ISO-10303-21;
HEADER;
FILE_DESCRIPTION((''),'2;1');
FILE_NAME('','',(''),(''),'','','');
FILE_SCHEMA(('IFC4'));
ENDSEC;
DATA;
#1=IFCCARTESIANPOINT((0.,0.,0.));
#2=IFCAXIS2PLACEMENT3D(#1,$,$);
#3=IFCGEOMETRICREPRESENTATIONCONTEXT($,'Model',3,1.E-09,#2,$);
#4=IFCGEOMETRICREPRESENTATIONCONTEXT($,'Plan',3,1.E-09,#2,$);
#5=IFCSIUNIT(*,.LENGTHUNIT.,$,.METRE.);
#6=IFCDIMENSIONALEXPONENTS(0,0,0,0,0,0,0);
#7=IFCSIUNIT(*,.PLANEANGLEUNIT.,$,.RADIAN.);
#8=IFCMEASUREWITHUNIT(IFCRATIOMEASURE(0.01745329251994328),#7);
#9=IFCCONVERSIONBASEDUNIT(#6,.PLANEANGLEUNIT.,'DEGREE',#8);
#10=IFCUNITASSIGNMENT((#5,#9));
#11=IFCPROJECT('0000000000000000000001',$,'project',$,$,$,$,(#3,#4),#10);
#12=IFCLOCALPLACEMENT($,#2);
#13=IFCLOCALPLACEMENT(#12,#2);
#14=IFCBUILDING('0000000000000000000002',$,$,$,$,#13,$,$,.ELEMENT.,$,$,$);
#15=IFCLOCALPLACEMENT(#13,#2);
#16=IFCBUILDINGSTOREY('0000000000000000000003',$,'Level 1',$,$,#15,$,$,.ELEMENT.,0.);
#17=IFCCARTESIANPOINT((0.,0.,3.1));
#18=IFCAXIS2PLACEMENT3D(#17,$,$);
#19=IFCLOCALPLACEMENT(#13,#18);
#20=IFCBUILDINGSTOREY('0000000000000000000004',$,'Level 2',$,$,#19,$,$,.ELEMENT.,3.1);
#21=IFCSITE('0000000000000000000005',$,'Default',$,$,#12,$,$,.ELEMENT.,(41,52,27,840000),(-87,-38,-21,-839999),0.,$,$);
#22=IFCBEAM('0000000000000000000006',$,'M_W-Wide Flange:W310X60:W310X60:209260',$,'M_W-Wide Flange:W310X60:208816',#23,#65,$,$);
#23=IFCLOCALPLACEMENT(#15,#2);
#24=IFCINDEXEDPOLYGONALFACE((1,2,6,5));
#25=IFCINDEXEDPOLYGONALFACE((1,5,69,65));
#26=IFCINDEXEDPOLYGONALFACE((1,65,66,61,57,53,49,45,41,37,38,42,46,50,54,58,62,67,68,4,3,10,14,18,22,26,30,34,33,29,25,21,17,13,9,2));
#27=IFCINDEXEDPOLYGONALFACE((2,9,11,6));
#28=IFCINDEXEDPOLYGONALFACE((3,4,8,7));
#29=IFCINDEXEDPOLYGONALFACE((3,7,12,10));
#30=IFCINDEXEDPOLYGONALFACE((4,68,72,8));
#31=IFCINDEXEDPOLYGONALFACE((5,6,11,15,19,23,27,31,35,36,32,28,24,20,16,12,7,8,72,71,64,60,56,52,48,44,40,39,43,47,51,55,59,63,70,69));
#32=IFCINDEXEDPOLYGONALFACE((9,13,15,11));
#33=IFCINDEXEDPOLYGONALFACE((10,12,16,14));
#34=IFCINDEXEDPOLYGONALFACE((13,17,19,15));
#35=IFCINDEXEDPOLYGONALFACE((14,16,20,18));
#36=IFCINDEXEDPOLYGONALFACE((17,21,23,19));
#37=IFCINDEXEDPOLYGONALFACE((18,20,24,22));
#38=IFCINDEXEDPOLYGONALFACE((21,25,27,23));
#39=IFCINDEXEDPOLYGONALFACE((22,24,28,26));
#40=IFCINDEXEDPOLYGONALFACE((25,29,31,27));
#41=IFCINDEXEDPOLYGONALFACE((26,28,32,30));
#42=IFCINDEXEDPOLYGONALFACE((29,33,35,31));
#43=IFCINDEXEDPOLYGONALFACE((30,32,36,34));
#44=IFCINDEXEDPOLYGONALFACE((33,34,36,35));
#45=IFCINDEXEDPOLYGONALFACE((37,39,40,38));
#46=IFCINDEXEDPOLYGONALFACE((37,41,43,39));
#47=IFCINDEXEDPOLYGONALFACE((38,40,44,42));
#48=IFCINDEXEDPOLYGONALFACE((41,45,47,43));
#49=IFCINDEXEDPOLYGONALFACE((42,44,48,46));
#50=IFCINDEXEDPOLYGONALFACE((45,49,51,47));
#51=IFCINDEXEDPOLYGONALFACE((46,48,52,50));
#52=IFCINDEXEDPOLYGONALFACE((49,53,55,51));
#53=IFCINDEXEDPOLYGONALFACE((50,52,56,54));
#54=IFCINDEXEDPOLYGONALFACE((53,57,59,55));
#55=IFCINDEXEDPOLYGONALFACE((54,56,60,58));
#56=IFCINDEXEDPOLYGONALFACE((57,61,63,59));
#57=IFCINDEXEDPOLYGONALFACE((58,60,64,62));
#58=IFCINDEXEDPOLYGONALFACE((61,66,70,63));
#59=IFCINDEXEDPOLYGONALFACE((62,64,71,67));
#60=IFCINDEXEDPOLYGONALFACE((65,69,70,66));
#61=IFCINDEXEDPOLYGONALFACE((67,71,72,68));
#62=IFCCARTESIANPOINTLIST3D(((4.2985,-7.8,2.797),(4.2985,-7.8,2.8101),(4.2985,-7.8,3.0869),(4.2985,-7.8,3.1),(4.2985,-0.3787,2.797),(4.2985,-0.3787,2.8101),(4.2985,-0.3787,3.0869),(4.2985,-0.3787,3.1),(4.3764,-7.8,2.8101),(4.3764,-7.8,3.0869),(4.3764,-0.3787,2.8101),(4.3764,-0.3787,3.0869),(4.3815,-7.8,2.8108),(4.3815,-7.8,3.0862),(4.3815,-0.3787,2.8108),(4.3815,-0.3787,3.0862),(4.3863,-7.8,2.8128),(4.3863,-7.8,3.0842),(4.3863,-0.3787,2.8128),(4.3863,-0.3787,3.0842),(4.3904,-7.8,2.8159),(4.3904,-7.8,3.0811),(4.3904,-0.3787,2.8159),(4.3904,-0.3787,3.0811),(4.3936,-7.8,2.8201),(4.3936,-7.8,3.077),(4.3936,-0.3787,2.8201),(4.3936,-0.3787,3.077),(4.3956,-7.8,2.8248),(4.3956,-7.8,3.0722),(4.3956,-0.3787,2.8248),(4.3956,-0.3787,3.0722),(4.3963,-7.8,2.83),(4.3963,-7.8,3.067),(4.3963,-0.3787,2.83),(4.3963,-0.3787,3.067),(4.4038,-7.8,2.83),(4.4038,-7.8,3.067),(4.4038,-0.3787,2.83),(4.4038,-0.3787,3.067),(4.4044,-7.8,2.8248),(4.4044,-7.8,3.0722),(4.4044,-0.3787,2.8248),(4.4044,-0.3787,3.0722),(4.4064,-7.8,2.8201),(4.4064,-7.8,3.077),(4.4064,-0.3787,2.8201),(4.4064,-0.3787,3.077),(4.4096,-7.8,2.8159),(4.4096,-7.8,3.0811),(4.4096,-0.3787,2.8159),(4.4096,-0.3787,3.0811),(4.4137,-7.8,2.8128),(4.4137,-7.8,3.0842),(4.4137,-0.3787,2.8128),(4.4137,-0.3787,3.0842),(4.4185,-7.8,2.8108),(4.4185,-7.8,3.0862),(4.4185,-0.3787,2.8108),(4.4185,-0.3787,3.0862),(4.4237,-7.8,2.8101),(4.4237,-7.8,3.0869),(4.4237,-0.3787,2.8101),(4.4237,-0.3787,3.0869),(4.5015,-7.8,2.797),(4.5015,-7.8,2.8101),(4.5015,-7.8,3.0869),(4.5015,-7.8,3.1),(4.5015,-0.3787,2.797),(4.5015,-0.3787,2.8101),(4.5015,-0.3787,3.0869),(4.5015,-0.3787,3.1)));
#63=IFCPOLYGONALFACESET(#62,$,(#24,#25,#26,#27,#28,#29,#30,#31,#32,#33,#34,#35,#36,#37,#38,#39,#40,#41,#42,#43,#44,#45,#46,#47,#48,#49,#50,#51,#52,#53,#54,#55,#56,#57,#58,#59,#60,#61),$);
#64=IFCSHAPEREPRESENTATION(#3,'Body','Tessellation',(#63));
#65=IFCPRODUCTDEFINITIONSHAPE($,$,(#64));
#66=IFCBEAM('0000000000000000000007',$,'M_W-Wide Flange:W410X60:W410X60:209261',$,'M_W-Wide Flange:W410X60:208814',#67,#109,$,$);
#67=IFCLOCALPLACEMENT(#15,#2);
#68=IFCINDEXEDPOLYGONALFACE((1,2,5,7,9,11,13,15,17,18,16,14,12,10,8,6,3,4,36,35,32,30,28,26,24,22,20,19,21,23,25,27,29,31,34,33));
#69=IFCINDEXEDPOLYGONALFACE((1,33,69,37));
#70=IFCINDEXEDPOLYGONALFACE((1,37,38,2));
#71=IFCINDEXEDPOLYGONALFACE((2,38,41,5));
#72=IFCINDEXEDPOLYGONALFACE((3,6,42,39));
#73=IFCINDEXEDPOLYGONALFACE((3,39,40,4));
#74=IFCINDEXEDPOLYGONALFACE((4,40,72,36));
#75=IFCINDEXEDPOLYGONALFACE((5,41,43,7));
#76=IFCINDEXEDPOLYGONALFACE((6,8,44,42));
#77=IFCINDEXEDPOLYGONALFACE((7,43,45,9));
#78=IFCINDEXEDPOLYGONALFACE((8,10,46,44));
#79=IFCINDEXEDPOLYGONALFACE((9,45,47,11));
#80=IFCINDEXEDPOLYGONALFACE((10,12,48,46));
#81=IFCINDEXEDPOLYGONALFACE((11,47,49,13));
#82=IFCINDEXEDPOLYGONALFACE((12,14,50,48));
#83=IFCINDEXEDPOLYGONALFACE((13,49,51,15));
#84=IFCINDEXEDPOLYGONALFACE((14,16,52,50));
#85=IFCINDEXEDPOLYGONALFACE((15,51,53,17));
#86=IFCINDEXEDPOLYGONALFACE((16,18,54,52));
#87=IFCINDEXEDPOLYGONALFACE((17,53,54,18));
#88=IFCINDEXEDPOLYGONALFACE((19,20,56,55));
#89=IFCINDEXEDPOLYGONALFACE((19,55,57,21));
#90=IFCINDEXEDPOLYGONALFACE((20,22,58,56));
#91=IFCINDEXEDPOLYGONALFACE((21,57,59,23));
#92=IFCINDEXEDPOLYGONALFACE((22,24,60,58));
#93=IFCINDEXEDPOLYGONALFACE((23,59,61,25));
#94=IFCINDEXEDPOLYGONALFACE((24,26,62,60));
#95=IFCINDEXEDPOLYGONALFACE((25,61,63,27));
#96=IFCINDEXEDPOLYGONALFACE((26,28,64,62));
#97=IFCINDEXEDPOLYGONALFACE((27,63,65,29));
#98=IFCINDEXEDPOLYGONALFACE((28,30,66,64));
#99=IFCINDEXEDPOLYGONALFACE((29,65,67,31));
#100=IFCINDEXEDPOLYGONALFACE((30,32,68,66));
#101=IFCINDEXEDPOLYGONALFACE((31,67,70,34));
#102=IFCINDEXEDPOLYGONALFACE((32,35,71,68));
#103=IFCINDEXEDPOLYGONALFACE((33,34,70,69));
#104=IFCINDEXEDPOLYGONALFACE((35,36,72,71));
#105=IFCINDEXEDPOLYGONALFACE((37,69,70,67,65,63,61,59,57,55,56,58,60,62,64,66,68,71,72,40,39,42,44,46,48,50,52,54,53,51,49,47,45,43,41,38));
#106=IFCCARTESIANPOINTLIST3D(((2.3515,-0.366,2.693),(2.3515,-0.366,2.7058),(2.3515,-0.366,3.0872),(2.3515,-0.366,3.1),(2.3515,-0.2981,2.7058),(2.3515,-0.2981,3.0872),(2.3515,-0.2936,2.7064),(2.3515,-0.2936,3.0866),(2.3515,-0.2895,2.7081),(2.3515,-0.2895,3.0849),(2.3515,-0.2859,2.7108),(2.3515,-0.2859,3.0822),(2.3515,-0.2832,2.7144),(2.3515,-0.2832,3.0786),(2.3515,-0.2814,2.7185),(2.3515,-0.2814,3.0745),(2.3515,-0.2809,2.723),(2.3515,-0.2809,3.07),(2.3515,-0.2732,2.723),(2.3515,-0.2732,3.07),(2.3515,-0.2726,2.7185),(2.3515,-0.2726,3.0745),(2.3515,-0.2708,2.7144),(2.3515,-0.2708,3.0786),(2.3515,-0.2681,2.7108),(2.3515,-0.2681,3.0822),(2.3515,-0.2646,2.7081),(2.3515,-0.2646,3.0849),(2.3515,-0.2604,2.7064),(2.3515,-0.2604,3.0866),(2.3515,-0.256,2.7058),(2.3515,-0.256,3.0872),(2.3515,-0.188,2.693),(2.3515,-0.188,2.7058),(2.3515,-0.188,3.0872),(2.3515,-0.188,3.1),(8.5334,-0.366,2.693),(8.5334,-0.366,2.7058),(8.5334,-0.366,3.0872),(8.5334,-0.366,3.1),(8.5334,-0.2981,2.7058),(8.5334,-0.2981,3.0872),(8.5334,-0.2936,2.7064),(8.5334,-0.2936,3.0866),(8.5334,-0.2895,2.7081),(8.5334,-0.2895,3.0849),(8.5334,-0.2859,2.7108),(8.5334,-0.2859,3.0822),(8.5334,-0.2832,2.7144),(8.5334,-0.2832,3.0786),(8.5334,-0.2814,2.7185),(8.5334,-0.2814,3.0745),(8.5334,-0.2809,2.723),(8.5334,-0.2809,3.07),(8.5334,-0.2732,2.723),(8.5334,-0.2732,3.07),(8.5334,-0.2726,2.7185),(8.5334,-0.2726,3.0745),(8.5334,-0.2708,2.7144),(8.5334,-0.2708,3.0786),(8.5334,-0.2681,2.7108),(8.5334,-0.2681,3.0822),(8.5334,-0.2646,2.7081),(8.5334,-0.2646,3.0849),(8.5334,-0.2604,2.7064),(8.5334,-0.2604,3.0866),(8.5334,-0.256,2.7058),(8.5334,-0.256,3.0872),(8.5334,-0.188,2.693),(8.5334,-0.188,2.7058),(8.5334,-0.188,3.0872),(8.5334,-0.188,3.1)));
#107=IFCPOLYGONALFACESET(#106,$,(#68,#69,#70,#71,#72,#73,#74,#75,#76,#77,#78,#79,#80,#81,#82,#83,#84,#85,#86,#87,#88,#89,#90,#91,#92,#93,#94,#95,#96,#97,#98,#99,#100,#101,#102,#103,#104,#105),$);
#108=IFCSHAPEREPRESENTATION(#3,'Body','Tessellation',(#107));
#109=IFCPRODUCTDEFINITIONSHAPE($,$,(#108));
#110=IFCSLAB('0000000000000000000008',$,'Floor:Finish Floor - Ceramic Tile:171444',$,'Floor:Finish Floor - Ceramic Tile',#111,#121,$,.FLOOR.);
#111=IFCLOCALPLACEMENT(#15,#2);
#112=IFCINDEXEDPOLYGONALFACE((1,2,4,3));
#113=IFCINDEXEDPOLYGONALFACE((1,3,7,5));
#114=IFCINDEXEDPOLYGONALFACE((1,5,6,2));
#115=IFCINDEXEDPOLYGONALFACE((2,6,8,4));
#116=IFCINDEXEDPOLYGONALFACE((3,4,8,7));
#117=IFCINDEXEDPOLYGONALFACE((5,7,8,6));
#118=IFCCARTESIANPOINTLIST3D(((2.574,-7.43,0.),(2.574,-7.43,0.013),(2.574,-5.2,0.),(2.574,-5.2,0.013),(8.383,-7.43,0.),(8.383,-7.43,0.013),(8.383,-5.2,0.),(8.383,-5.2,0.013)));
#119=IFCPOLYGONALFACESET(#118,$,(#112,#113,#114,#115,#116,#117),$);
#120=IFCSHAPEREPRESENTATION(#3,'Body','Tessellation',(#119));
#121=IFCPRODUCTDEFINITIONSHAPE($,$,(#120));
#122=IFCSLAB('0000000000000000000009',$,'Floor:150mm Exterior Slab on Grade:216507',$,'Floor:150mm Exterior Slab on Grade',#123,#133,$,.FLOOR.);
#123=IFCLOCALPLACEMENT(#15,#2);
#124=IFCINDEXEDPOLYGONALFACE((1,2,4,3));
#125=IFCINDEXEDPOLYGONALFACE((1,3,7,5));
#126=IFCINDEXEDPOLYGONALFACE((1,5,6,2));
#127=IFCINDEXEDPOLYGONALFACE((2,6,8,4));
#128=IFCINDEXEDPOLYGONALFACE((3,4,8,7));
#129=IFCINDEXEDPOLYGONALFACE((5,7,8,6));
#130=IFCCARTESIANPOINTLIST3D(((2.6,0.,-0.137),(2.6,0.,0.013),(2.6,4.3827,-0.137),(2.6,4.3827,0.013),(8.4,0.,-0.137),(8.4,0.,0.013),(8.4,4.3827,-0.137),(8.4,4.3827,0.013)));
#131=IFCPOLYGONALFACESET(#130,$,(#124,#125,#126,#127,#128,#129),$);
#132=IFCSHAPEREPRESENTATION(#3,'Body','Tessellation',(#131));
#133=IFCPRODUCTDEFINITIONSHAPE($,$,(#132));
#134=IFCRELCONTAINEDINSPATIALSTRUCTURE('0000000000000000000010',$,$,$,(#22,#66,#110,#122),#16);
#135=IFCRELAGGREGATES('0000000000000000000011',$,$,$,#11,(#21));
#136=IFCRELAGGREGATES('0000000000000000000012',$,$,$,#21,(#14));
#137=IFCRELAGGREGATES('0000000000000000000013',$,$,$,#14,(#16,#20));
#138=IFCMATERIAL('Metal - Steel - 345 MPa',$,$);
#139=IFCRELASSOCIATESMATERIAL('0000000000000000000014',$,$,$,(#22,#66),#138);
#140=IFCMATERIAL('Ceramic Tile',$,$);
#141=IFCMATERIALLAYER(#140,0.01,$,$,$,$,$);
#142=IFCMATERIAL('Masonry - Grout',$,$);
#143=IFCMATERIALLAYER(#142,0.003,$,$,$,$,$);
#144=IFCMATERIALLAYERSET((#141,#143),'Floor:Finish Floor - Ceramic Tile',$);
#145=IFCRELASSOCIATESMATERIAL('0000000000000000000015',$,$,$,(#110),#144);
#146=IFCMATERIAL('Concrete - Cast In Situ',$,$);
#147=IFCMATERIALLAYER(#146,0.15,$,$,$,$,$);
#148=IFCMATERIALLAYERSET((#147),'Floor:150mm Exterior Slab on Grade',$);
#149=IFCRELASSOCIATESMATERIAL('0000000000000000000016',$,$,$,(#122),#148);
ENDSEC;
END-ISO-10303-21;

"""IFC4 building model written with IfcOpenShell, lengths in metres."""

from ifc_helpers import new_model, entity, si_unit, converted_unit, frame, frame_2d, origin, place, context, project, spatial, polyline, circle_curve, parameter, trimmed, segment, composite_curve, rectangle, outline, extrude, material, layer, layer_set, layer_usage, element, save


model = new_model("IFC4")

# Units and contexts
model_context = context("Model", 3, precision=1e-09, world=origin())
plan_context = context("Plan", 3, precision=1e-09, world=origin())
ifc_project = project(units=[si_unit("LENGTHUNIT", "METRE"), converted_unit("PLANEANGLEUNIT", "DEGREE", entity("IfcRatioMeasure", 0.01745329251994328), si_unit("PLANEANGLEUNIT", "RADIAN"), dimensions=[0, 0, 0, 0, 0, 0, 0])], contexts=[model_context, plan_context])

# Site, building, storey
site_placement = place(None, origin())
site = spatial("IfcSite", under=ifc_project, at=site_placement, Name="Default", CompositionType="ELEMENT", RefLatitude=(41, 52, 27, 840000), RefLongitude=(-87, -38, -21, -839999), RefElevation=0.0)
building_placement = place(site_placement, origin())
building = spatial("IfcBuilding", under=site, at=building_placement, CompositionType="ELEMENT")
storey_1_placement = place(building_placement, origin())
storey_1 = spatial("IfcBuildingStorey", under=building, at=storey_1_placement, Name="Level 1", CompositionType="ELEMENT", Elevation=0.0)

# Beams
ifc_material_1 = material(Name="Metal - Steel - 345 MPa")
beam_1_placement = place(storey_1_placement, frame((4.4, -7.8, 3.1)))
element("IfcBeam", 1, at=beam_1_placement, inside=storey_1, material=ifc_material_1, Name="M_W-Wide Flange:W310X60:W310X60:209260", ObjectType="M_W-Wide Flange:W310X60:208816", context=model_context, shape_type="SweptSolid", body=[
    extrude(outline(composite_curve([segment(polyline([(-0.1015, -0.1384), (-0.1015, -0.1515)]), True, "CONTINUOUS"), segment(polyline([(-0.1015, -0.1515), (0.1015, -0.1515)]), True, "CONTINUOUS"), segment(polyline([(0.1015, -0.1515), (0.1015, -0.1384)]), True, "CONTINUOUS"), segment(polyline([(0.1015, -0.1384), (0.0236, -0.1384)]), True, "CONTINUOUS"), segment(trimmed(circle_curve(frame_2d((0.0236, -0.1185), x_axis=(1.0, 0.0)), 0.0199), [parameter(180.0)], [parameter(270.0)], True, "PARAMETER"), False, "CONTINUOUS"), segment(polyline([(0.0037, -0.1185), (0.0037, 0.1185)]), True, "CONTINUOUS"), segment(trimmed(circle_curve(frame_2d((0.0236, 0.1185), x_axis=(1.0, 0.0)), 0.0199), [parameter(90.0)], [parameter(180.0)], True, "PARAMETER"), False, "CONTINUOUS"), segment(polyline([(0.0236, 0.1384), (0.1015, 0.1384)]), True, "CONTINUOUS"), segment(polyline([(0.1015, 0.1384), (0.1015, 0.1515)]), True, "CONTINUOUS"), segment(polyline([(0.1015, 0.1515), (-0.1015, 0.1515)]), True, "CONTINUOUS"), segment(polyline([(-0.1015, 0.1515), (-0.1015, 0.1384)]), True, "CONTINUOUS"), segment(polyline([(-0.1015, 0.1384), (-0.0237, 0.1384)]), True, "CONTINUOUS"), segment(trimmed(circle_curve(frame_2d((-0.0237, 0.1185), x_axis=(1.0, 0.0)), 0.0199), [parameter(360.0)], [parameter(90.0)], True, "PARAMETER"), False, "CONTINUOUS"), segment(polyline([(-0.0038, 0.1185), (-0.0038, -0.1185)]), True, "CONTINUOUS"), segment(trimmed(circle_curve(frame_2d((-0.0237, -0.1185), x_axis=(1.0, 0.0)), 0.0199), [parameter(270.0)], [parameter(0.0)], True, "PARAMETER"), False, "CONTINUOUS"), segment(polyline([(-0.0237, -0.1384), (-0.1015, -0.1384)]), True, "CONTINUOUS")], self_intersect=False)), frame((0.0, 0.0, -0.1515), z_axis=(0.0, -1.0, 0.0), x_axis=(1.0, 0.0, 0.0)), (0.0, 0.0, -1.0), 7.4213),
])
beam_2_placement = place(storey_1_placement, frame((8.5915, -0.277, 3.1), z_axis=(0.0, 0.0, 1.0), x_axis=(0.0, 1.0, 0.0)))
element("IfcBeam", 2, at=beam_2_placement, inside=storey_1, material=ifc_material_1, Name="M_W-Wide Flange:W410X60:W410X60:209261", ObjectType="M_W-Wide Flange:W410X60:208814", context=model_context, shape_type="SweptSolid", body=[
    extrude(outline(composite_curve([segment(polyline([(0.1907, -0.089), (0.2035, -0.089)]), True, "CONTINUOUS"), segment(polyline([(0.2035, -0.089), (0.2035, 0.089)]), True, "CONTINUOUS"), segment(polyline([(0.2035, 0.089), (0.1907, 0.089)]), True, "CONTINUOUS"), segment(polyline([(0.1907, 0.089), (0.1907, 0.021)]), True, "CONTINUOUS"), segment(trimmed(circle_curve(frame_2d((0.1735, 0.021), x_axis=(1.0, 0.0)), 0.0172), [parameter(270.0)], [parameter(360.0)], True, "PARAMETER"), False, "CONTINUOUS"), segment(polyline([(0.1735, 0.0038), (-0.1735, 0.0038)]), True, "CONTINUOUS"), segment(trimmed(circle_curve(frame_2d((-0.1735, 0.021), x_axis=(0.0, -1.0)), 0.0172), [parameter(270.0)], [parameter(360.0)], True, "PARAMETER"), False, "CONTINUOUS"), segment(polyline([(-0.1907, 0.021), (-0.1907, 0.089)]), True, "CONTINUOUS"), segment(polyline([(-0.1907, 0.089), (-0.2035, 0.089)]), True, "CONTINUOUS"), segment(polyline([(-0.2035, 0.089), (-0.2035, -0.089)]), True, "CONTINUOUS"), segment(polyline([(-0.2035, -0.089), (-0.1907, -0.089)]), True, "CONTINUOUS"), segment(polyline([(-0.1907, -0.089), (-0.1907, -0.0211)]), True, "CONTINUOUS"), segment(trimmed(circle_curve(frame_2d((-0.1735, -0.0211), x_axis=(-1.0, 0.0)), 0.0172), [parameter(270.0)], [parameter(0.0)], True, "PARAMETER"), False, "CONTINUOUS"), segment(polyline([(-0.1735, -0.0039), (0.1735, -0.0039)]), True, "CONTINUOUS"), segment(trimmed(circle_curve(frame_2d((0.1735, -0.0211), x_axis=(0.0, 1.0)), 0.0172), [parameter(270.0)], [parameter(0.0)], True, "PARAMETER"), False, "CONTINUOUS"), segment(polyline([(0.1907, -0.0211), (0.1907, -0.089)]), True, "CONTINUOUS")], self_intersect=False)), frame((0.0, 6.24, -0.2035), z_axis=(0.0, -1.0, 0.0), x_axis=(0.0, 0.0, -1.0)), (0.0, 0.0, 1.0), 6.1819),
])

# Slabs
ifc_material_2 = material(Name="Ceramic Tile")
ifc_layer_1 = layer(ifc_material_2, 0.01)
ifc_material_3 = material(Name="Masonry - Grout")
ifc_layer_2 = layer(ifc_material_3, 0.003)
ifc_layer_set_1 = layer_set([ifc_layer_1, ifc_layer_2], Name="Floor:Finish Floor - Ceramic Tile")
ifc_layer_usage_1 = layer_usage(ifc_layer_set_1, "AXIS3", "POSITIVE", 0.0)
slab_1_placement = place(storey_1_placement, frame((2.574, -7.43, 0.0)))
element("IfcSlab", 3, at=slab_1_placement, inside=storey_1, material=ifc_layer_usage_1, Name="Floor:Finish Floor - Ceramic Tile:171444", ObjectType="Floor:Finish Floor - Ceramic Tile", PredefinedType="FLOOR", context=model_context, shape_type="SweptSolid", body=[
    extrude(rectangle(XDim=5.809, YDim=2.23, at=frame_2d((0.0, 0.0), x_axis=(-1.0, 0.0))), frame((2.9045, 1.115, 0.013), z_axis=(0.0, 0.0, -1.0), x_axis=(-1.0, 0.0, 0.0)), (0.0, 0.0, 1.0), 0.013),
])
ifc_material_4 = material(Name="Concrete - Cast In Situ")
ifc_layer_3 = layer(ifc_material_4, 0.15)
ifc_layer_set_2 = layer_set([ifc_layer_3], Name="Floor:150mm Exterior Slab on Grade")
ifc_layer_usage_2 = layer_usage(ifc_layer_set_2, "AXIS3", "POSITIVE", 0.0)
slab_2_placement = place(storey_1_placement, frame((2.6, 0.0, -0.137)))
element("IfcSlab", 4, at=slab_2_placement, inside=storey_1, material=ifc_layer_usage_2, Name="Floor:150mm Exterior Slab on Grade:216507", ObjectType="Floor:150mm Exterior Slab on Grade", PredefinedType="FLOOR", context=model_context, shape_type="SweptSolid", body=[
    extrude(rectangle(XDim=5.8, YDim=4.3827, at=frame_2d((0.0, 0.0), x_axis=(-1.0, 0.0))), frame((2.9, 2.1914, 0.15), z_axis=(0.0, 0.0, -1.0), x_axis=(-1.0, 0.0, 0.0)), (0.0, 0.0, 1.0), 0.15),
])

# Shared definitions
storey_2_placement = place(building_placement, frame((0.0, 0.0, 3.1)))
storey_2 = spatial("IfcBuildingStorey", under=building, at=storey_2_placement, Name="Level 2", CompositionType="ELEMENT", Elevation=3.1)

save(model, "model.ifc")
